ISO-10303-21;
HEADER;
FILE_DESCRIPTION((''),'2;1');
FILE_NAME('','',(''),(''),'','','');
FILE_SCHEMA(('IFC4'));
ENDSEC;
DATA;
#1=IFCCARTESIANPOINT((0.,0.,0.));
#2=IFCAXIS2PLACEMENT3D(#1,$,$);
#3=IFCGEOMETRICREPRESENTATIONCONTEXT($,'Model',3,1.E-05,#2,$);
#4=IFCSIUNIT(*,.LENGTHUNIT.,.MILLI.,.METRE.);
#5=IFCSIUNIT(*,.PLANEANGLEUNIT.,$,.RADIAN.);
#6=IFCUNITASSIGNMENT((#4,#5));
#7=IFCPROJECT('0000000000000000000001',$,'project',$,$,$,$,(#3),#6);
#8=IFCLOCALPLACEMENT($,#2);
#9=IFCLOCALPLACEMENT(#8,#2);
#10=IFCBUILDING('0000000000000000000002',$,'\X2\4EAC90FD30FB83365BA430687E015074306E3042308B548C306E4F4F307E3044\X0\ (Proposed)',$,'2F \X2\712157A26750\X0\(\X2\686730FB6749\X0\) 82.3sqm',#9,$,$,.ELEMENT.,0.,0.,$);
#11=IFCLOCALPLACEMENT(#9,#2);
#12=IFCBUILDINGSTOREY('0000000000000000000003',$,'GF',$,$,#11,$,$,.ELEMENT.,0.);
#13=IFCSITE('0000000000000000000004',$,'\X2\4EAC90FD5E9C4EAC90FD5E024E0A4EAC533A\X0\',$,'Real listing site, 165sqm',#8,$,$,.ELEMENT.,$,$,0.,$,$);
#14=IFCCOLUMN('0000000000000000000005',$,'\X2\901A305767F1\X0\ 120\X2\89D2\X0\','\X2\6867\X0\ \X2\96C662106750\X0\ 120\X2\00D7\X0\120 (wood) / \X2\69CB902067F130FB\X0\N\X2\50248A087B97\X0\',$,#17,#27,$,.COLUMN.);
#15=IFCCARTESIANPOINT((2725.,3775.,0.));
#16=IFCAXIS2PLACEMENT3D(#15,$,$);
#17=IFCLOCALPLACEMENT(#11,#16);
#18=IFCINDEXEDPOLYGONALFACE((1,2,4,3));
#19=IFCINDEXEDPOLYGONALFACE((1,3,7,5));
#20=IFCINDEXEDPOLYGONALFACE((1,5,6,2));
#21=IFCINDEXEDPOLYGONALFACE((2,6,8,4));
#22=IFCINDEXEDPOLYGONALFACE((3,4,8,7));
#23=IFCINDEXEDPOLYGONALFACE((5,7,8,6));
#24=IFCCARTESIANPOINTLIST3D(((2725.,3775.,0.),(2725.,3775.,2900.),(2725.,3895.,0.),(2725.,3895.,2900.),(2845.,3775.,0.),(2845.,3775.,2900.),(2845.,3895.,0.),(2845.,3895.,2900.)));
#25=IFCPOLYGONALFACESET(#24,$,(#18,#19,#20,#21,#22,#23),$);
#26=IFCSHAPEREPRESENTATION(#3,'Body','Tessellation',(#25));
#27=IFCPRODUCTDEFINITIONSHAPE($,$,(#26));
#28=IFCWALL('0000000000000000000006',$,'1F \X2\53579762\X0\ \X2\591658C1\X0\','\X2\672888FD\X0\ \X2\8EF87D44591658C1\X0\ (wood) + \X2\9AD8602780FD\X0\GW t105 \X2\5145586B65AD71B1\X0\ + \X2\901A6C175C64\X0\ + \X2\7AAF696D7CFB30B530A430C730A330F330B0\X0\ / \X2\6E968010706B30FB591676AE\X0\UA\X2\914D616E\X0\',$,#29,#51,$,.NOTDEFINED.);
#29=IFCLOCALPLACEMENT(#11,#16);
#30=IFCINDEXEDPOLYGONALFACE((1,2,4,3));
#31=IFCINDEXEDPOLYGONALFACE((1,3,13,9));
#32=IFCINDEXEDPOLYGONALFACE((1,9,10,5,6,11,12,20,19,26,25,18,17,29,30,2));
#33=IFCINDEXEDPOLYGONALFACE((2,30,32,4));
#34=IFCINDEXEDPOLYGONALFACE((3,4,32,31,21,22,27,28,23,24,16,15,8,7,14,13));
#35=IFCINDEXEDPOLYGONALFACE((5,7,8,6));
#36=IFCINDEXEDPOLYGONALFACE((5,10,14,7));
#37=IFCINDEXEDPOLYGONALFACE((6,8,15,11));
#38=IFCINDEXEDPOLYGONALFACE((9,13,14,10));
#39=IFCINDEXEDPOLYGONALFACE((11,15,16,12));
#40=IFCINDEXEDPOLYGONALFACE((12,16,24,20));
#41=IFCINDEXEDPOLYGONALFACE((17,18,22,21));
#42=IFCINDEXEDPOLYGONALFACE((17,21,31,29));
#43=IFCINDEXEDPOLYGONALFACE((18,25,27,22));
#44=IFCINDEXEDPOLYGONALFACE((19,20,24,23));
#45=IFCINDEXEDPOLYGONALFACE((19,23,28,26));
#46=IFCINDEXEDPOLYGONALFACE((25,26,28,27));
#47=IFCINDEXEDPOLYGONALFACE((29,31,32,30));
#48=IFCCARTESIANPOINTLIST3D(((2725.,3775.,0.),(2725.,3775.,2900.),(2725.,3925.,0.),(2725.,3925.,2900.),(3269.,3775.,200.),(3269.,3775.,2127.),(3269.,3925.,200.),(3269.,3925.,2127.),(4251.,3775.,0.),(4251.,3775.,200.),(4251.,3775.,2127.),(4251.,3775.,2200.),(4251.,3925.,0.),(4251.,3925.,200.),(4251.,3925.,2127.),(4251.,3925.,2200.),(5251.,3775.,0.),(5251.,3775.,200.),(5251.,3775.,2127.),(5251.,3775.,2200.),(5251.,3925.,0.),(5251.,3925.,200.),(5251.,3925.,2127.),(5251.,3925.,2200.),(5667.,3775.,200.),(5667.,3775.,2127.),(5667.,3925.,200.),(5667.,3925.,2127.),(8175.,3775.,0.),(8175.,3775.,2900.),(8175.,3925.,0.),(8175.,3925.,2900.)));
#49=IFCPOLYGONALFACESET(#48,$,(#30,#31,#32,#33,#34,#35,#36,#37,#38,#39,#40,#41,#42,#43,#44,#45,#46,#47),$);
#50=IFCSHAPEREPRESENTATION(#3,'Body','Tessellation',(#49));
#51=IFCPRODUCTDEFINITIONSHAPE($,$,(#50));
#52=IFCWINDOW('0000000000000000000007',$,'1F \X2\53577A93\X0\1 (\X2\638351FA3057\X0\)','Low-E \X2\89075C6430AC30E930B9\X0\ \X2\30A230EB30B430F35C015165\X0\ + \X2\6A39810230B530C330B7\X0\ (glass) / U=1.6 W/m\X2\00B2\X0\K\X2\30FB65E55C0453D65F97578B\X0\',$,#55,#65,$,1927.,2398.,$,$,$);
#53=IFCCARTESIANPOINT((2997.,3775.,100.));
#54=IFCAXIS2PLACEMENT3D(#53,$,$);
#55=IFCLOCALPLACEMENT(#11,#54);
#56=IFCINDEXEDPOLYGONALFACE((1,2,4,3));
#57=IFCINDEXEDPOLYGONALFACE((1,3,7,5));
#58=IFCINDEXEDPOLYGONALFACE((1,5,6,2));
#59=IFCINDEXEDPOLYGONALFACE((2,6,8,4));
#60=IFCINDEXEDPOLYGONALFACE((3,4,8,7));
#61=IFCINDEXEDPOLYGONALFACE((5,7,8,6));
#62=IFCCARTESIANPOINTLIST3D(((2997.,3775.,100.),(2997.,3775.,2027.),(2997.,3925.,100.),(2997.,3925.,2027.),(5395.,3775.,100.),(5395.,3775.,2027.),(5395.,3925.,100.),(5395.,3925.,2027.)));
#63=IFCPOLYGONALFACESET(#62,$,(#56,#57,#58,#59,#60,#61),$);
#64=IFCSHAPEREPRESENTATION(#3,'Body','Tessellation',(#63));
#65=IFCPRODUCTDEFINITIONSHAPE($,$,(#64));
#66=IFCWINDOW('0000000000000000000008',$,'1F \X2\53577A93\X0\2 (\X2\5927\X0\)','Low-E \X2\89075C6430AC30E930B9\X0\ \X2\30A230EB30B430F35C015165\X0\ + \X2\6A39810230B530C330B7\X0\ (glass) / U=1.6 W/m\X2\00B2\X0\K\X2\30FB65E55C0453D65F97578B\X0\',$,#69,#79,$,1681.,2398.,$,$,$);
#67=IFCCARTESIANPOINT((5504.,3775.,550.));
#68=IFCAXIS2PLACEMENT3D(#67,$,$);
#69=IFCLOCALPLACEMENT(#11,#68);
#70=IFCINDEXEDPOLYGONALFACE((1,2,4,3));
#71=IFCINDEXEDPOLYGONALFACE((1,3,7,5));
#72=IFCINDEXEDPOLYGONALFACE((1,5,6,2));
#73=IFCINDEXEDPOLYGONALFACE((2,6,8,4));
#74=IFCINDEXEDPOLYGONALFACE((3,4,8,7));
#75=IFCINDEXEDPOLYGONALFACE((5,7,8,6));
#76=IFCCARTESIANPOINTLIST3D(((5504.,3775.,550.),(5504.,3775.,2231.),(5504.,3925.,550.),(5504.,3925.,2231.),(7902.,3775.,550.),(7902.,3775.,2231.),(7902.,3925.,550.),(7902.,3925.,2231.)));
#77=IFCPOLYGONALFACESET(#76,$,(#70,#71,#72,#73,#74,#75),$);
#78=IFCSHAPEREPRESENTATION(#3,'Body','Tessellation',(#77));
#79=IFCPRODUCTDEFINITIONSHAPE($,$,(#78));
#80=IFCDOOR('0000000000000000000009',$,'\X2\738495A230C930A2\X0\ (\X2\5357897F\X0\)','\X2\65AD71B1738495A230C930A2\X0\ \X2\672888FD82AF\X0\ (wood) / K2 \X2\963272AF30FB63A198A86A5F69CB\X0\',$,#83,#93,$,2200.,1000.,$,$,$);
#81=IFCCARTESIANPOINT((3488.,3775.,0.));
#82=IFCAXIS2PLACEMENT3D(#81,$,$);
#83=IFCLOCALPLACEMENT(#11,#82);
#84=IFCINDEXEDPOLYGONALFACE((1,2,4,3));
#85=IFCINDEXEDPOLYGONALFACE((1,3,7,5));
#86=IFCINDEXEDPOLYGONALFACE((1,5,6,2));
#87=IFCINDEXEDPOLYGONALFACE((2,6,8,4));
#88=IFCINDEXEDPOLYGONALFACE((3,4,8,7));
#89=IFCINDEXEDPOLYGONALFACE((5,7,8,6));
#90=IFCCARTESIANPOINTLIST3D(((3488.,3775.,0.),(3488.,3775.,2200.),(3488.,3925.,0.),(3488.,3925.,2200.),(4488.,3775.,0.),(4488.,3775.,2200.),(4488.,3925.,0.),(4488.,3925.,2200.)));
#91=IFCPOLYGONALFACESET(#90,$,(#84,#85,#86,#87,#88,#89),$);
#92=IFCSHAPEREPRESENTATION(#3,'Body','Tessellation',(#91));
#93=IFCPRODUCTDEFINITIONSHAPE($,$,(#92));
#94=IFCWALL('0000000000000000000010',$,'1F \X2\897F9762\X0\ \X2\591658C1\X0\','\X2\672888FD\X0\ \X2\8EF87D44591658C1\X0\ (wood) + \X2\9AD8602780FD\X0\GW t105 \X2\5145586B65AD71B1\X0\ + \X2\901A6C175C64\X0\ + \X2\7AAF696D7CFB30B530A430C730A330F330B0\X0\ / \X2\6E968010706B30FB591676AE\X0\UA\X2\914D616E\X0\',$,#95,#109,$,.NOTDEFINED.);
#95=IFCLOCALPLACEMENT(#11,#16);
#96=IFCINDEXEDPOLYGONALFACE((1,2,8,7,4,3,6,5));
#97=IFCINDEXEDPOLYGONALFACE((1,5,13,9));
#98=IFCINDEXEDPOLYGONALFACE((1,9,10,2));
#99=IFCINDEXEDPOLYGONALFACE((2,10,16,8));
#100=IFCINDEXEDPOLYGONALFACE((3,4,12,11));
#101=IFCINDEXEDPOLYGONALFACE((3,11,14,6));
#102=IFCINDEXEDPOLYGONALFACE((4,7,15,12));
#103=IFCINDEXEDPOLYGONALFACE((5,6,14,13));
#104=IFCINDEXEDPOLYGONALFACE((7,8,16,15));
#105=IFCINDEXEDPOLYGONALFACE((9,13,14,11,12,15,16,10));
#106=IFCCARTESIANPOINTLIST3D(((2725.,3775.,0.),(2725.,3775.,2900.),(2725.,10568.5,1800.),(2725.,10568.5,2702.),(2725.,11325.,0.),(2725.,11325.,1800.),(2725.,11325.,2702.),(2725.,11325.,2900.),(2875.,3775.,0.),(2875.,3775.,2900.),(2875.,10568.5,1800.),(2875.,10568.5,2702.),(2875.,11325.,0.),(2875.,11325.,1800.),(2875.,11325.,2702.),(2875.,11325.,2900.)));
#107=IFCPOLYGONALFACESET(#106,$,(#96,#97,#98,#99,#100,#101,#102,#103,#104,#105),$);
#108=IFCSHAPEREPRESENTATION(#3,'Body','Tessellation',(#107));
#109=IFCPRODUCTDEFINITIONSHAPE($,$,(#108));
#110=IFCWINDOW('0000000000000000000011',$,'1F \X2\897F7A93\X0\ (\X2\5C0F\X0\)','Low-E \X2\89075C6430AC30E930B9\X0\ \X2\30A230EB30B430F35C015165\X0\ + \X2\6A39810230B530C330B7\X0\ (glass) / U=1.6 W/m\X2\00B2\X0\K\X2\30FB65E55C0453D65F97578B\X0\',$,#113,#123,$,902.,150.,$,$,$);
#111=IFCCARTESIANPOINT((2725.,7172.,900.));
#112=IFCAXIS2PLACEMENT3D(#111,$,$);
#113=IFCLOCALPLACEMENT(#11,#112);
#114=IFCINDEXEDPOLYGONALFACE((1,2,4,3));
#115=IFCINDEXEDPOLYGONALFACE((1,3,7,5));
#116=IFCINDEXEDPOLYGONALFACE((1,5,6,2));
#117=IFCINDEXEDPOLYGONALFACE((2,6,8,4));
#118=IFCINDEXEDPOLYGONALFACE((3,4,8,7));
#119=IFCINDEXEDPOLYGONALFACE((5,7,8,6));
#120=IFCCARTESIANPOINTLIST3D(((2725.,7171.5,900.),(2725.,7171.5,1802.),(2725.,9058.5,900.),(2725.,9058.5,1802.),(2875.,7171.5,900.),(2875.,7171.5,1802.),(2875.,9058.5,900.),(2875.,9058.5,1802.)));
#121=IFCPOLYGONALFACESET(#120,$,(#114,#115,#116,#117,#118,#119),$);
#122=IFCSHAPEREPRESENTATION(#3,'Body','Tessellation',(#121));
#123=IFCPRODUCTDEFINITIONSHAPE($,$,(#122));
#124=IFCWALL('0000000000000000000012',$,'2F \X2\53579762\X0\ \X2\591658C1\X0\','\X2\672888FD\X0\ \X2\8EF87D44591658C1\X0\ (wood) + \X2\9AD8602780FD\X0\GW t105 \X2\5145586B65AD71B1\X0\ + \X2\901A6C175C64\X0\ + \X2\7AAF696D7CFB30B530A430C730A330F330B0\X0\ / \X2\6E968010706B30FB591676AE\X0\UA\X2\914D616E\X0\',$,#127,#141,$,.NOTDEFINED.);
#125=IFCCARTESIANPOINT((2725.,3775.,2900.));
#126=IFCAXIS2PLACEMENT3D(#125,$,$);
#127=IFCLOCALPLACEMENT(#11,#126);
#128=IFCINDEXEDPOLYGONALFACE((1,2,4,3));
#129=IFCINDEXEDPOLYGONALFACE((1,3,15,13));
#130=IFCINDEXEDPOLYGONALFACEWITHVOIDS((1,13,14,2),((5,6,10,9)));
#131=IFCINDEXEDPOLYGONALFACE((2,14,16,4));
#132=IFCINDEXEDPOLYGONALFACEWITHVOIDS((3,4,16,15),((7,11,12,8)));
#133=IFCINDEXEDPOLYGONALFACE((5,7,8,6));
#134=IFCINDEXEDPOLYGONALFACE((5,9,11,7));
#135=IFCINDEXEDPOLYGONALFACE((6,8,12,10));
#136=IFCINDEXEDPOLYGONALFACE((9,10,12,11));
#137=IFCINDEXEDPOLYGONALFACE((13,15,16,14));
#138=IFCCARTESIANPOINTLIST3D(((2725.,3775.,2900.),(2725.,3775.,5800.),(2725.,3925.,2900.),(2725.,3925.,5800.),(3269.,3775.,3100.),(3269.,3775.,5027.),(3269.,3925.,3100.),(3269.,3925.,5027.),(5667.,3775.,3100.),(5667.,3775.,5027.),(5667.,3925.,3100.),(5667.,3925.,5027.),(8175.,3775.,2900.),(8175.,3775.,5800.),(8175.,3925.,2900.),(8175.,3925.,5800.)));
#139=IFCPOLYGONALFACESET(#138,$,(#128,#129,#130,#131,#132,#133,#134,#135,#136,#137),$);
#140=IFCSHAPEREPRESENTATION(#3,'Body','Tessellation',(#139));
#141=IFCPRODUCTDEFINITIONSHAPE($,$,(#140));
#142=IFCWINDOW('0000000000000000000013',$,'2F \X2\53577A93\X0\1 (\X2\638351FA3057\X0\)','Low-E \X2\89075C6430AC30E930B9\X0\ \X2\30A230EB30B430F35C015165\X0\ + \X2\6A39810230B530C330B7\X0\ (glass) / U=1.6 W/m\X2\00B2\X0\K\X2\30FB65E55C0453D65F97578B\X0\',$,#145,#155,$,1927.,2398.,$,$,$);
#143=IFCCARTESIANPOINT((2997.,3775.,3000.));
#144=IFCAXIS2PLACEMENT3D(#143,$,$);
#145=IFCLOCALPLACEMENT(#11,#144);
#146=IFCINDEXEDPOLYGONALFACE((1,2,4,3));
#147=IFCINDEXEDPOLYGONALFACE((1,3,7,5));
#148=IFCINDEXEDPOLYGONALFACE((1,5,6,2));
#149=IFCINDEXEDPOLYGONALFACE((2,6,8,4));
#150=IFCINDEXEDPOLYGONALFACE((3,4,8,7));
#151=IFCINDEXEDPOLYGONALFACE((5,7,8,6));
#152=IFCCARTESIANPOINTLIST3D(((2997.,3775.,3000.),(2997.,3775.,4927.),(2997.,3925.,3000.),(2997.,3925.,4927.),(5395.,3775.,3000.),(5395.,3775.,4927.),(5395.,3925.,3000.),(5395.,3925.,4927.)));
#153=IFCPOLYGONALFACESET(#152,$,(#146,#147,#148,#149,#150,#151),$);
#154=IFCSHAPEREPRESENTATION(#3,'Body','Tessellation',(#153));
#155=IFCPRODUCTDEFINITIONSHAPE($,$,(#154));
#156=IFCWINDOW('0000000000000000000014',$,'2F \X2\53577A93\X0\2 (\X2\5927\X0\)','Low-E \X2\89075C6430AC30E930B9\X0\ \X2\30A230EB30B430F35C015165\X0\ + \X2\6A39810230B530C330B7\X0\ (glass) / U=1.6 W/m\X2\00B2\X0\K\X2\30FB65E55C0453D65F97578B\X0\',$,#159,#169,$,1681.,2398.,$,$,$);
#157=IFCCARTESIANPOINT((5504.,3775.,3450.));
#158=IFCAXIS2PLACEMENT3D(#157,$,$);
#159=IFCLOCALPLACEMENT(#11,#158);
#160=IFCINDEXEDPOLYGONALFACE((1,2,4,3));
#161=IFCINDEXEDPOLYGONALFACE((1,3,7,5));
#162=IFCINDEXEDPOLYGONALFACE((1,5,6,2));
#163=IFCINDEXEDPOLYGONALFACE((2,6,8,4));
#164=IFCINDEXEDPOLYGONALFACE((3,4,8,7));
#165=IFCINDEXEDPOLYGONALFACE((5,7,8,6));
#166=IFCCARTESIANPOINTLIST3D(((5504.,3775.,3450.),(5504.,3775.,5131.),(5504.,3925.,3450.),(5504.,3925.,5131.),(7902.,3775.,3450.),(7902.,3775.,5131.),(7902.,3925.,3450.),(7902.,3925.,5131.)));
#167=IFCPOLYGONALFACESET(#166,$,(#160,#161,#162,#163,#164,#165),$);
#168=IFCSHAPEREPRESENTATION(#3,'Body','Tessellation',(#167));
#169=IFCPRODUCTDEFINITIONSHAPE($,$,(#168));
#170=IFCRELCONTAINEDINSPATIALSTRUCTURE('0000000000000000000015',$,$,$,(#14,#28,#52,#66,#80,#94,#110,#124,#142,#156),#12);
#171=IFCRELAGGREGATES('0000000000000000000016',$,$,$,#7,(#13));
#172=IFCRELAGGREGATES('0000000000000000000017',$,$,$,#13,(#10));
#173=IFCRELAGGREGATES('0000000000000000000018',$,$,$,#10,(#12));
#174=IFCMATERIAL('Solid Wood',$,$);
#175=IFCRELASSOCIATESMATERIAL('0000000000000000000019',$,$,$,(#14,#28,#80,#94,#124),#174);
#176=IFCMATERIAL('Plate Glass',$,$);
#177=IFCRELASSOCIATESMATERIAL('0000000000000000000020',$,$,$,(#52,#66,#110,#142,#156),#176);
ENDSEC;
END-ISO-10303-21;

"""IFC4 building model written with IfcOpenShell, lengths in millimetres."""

from ifc_helpers import new_model, si_unit, frame, frame_2d, origin, place, context, project, spatial, rectangle, extrude, material, element, fill, save


model = new_model("IFC4")

# Units and contexts
model_context = context("Model", 3, precision=1e-05, world=origin())
ifc_project = project(units=[si_unit("LENGTHUNIT", "METRE", prefix="MILLI"), si_unit("PLANEANGLEUNIT", "RADIAN")], contexts=[model_context])

# Site, building, storey
site_placement = place(None, origin())
site = spatial("IfcSite", under=ifc_project, at=site_placement, Name="京都府京都市上京区", ObjectType="Real listing site, 165sqm", CompositionType="ELEMENT", RefElevation=0.0)
building_placement = place(site_placement, origin())
building = spatial("IfcBuilding", under=site, at=building_placement, Name="京都・茶室と縁側のある和の住まい (Proposed)", ObjectType="2F 無垢材(桧・杉) 82.3sqm", CompositionType="ELEMENT", ElevationOfRefHeight=0.0, ElevationOfTerrain=0.0)
storey_placement = place(building_placement, origin())
storey = spatial("IfcBuildingStorey", under=building, at=storey_placement, Name="GF", CompositionType="ELEMENT", Elevation=0.0)

# Column
ifc_material_1 = material(Name="Solid Wood")
column_placement = place(storey_placement, frame((2725.0, 3775.0, 0.0)))
element("IfcColumn", 1, at=column_placement, inside=storey, material=ifc_material_1, Name="通し柱 120角", Description="桧 集成材 120×120 (wood) / 構造柱・N値計算", PredefinedType="COLUMN", context=model_context, shape_type="SweptSolid", body=[
    extrude(rectangle(XDim=120.0, YDim=120.0, at=frame_2d((60.0, 60.0))), frame((2725.0, 3775.0, 0.0)), (0.0, 0.0, 1.0), 2900.0),
])

# Wall, openings, windows, door
wall_1_placement = place(storey_placement, frame((2725.0, 3775.0, 0.0)))
wall_1 = element("IfcWall", 2, at=wall_1_placement, inside=storey, material=ifc_material_1, Name="1F 南面 外壁", Description="木製 軸組外壁 (wood) + 高性能GW t105 充填断熱 + 通気層 + 窯業系サイディング / 準耐火・外皮UA配慮", PredefinedType="NOTDEFINED", context=model_context, shape_type="SweptSolid", body=[
    extrude(rectangle(XDim=5450.0, YDim=150.0, at=frame_2d((2725.0, 75.0))), frame((2725.0, 3775.0, 0.0)), (0.0, 0.0, 1.0), 2900.0),
])
opening_1_placement = place(storey_placement, frame((2997.0, 3775.0, 100.0)))
opening_1 = element("IfcOpeningElement", 3, at=opening_1_placement, cuts=wall_1, PredefinedType="NOTDEFINED", context=model_context, shape_type="SweptSolid", body=[
    extrude(rectangle(XDim=2398.0, YDim=150.0, at=frame_2d((1199.0, 75.0))), frame((2997.0, 3775.0, 100.0)), (0.0, 0.0, 1.0), 1927.0),
])
opening_2_placement = place(storey_placement, frame((5504.0, 3775.0, 550.0)))
opening_2 = element("IfcOpeningElement", 4, at=opening_2_placement, cuts=wall_1, PredefinedType="NOTDEFINED", context=model_context, shape_type="SweptSolid", body=[
    extrude(rectangle(XDim=2398.0, YDim=150.0, at=frame_2d((1199.0, 75.0))), frame((5504.0, 3775.0, 550.0)), (0.0, 0.0, 1.0), 1681.0),
])
opening_3_placement = place(storey_placement, frame((3488.0, 3775.0, 0.0)))
opening_3 = element("IfcOpeningElement", 5, at=opening_3_placement, cuts=wall_1, PredefinedType="NOTDEFINED", context=model_context, shape_type="SweptSolid", body=[
    extrude(rectangle(XDim=1000.0, YDim=150.0, at=frame_2d((500.0, 75.0))), frame((3488.0, 3775.0, 0.0)), (0.0, 0.0, 1.0), 2200.0),
])
ifc_material_2 = material(Name="Plate Glass")
window_1_placement = place(storey_placement, frame((2997.0, 3775.0, 100.0)))
window_1 = element("IfcWindow", 6, at=window_1_placement, inside=storey, material=ifc_material_2, Name="1F 南窓1 (掃出し)", Description="Low-E 複層ガラス アルゴン封入 + 樹脂サッシ (glass) / U=1.6 W/m²K・日射取得型", OverallHeight=1927.0, OverallWidth=2398.0, context=model_context, shape_type="SweptSolid", body=[
    extrude(rectangle(XDim=2398.0, YDim=150.0, at=frame_2d((1199.0, 75.0))), frame((2997.0, 3775.0, 100.0)), (0.0, 0.0, 1.0), 1927.0),
])
fill(opening_1, window_1)
window_2_placement = place(storey_placement, frame((5504.0, 3775.0, 550.0)))
window_2 = element("IfcWindow", 7, at=window_2_placement, inside=storey, material=ifc_material_2, Name="1F 南窓2 (大)", Description="Low-E 複層ガラス アルゴン封入 + 樹脂サッシ (glass) / U=1.6 W/m²K・日射取得型", OverallHeight=1681.0, OverallWidth=2398.0, context=model_context, shape_type="SweptSolid", body=[
    extrude(rectangle(XDim=2398.0, YDim=150.0, at=frame_2d((1199.0, 75.0))), frame((5504.0, 3775.0, 550.0)), (0.0, 0.0, 1.0), 1681.0),
])
fill(opening_2, window_2)
door_placement = place(storey_placement, frame((3488.0, 3775.0, 0.0)))
door = element("IfcDoor", 8, at=door_placement, inside=storey, material=ifc_material_1, Name="玄関ドア (南西)", Description="断熱玄関ドア 木製芯 (wood) / K2 防犯・採風機構", OverallHeight=2200.0, OverallWidth=1000.0, context=model_context, shape_type="SweptSolid", body=[
    extrude(rectangle(XDim=1000.0, YDim=150.0, at=frame_2d((500.0, 75.0))), frame((3488.0, 3775.0, 0.0)), (0.0, 0.0, 1.0), 2200.0),
])
fill(opening_3, door)

# Wall, opening, window
wall_2_placement = place(storey_placement, frame((2725.0, 3775.0, 0.0)))
wall_2 = element("IfcWall", 9, at=wall_2_placement, inside=storey, material=ifc_material_1, Name="1F 西面 外壁", Description="木製 軸組外壁 (wood) + 高性能GW t105 充填断熱 + 通気層 + 窯業系サイディング / 準耐火・外皮UA配慮", PredefinedType="NOTDEFINED", context=model_context, shape_type="SweptSolid", body=[
    extrude(rectangle(XDim=150.0, YDim=7550.0, at=frame_2d((75.0, 3775.0))), frame((2725.0, 3775.0, 0.0)), (0.0, 0.0, 1.0), 2900.0),
])
opening_4_placement = place(storey_placement, frame((2725.0, 7172.0, 900.0)))
opening_4 = element("IfcOpeningElement", 10, at=opening_4_placement, cuts=wall_2, PredefinedType="NOTDEFINED", context=model_context, shape_type="SweptSolid", body=[
    extrude(rectangle(XDim=150.0, YDim=1887.0, at=frame_2d((75.0, 943.0))), frame((2725.0, 7172.0, 900.0)), (0.0, 0.0, 1.0), 902.0),
])
window_3_placement = place(storey_placement, frame((2725.0, 7172.0, 900.0)))
window_3 = element("IfcWindow", 11, at=window_3_placement, inside=storey, material=ifc_material_2, Name="1F 西窓 (小)", Description="Low-E 複層ガラス アルゴン封入 + 樹脂サッシ (glass) / U=1.6 W/m²K・日射取得型", OverallHeight=902.0, OverallWidth=150.0, context=model_context, shape_type="SweptSolid", body=[
    extrude(rectangle(XDim=150.0, YDim=1887.0, at=frame_2d((75.0, 943.0))), frame((2725.0, 7172.0, 900.0)), (0.0, 0.0, 1.0), 902.0),
])
fill(opening_4, window_3)

# Wall, openings, windows
wall_3_placement = place(storey_placement, frame((2725.0, 3775.0, 2900.0)))
wall_3 = element("IfcWall", 12, at=wall_3_placement, inside=storey, material=ifc_material_1, Name="2F 南面 外壁", Description="木製 軸組外壁 (wood) + 高性能GW t105 充填断熱 + 通気層 + 窯業系サイディング / 準耐火・外皮UA配慮", PredefinedType="NOTDEFINED", context=model_context, shape_type="SweptSolid", body=[
    extrude(rectangle(XDim=5450.0, YDim=150.0, at=frame_2d((2725.0, 75.0))), frame((2725.0, 3775.0, 2900.0)), (0.0, 0.0, 1.0), 2900.0),
])
opening_5_placement = place(storey_placement, frame((2997.0, 3775.0, 3000.0)))
opening_5 = element("IfcOpeningElement", 13, at=opening_5_placement, cuts=wall_3, PredefinedType="NOTDEFINED", context=model_context, shape_type="SweptSolid", body=[
    extrude(rectangle(XDim=2398.0, YDim=150.0, at=frame_2d((1199.0, 75.0))), frame((2997.0, 3775.0, 3000.0)), (0.0, 0.0, 1.0), 1927.0),
])
opening_6_placement = place(storey_placement, frame((5504.0, 3775.0, 3450.0)))
opening_6 = element("IfcOpeningElement", 14, at=opening_6_placement, cuts=wall_3, PredefinedType="NOTDEFINED", context=model_context, shape_type="SweptSolid", body=[
    extrude(rectangle(XDim=2398.0, YDim=150.0, at=frame_2d((1199.0, 75.0))), frame((5504.0, 3775.0, 3450.0)), (0.0, 0.0, 1.0), 1681.0),
])
window_4_placement = place(storey_placement, frame((2997.0, 3775.0, 3000.0)))
window_4 = element("IfcWindow", 15, at=window_4_placement, inside=storey, material=ifc_material_2, Name="2F 南窓1 (掃出し)", Description="Low-E 複層ガラス アルゴン封入 + 樹脂サッシ (glass) / U=1.6 W/m²K・日射取得型", OverallHeight=1927.0, OverallWidth=2398.0, context=model_context, shape_type="SweptSolid", body=[
    extrude(rectangle(XDim=2398.0, YDim=150.0, at=frame_2d((1199.0, 75.0))), frame((2997.0, 3775.0, 3000.0)), (0.0, 0.0, 1.0), 1927.0),
])
fill(opening_5, window_4)
window_5_placement = place(storey_placement, frame((5504.0, 3775.0, 3450.0)))
window_5 = element("IfcWindow", 16, at=window_5_placement, inside=storey, material=ifc_material_2, Name="2F 南窓2 (大)", Description="Low-E 複層ガラス アルゴン封入 + 樹脂サッシ (glass) / U=1.6 W/m²K・日射取得型", OverallHeight=1681.0, OverallWidth=2398.0, context=model_context, shape_type="SweptSolid", body=[
    extrude(rectangle(XDim=2398.0, YDim=150.0, at=frame_2d((1199.0, 75.0))), frame((5504.0, 3775.0, 3450.0)), (0.0, 0.0, 1.0), 1681.0),
])
fill(opening_6, window_5)

save(model, "model.ifc")
